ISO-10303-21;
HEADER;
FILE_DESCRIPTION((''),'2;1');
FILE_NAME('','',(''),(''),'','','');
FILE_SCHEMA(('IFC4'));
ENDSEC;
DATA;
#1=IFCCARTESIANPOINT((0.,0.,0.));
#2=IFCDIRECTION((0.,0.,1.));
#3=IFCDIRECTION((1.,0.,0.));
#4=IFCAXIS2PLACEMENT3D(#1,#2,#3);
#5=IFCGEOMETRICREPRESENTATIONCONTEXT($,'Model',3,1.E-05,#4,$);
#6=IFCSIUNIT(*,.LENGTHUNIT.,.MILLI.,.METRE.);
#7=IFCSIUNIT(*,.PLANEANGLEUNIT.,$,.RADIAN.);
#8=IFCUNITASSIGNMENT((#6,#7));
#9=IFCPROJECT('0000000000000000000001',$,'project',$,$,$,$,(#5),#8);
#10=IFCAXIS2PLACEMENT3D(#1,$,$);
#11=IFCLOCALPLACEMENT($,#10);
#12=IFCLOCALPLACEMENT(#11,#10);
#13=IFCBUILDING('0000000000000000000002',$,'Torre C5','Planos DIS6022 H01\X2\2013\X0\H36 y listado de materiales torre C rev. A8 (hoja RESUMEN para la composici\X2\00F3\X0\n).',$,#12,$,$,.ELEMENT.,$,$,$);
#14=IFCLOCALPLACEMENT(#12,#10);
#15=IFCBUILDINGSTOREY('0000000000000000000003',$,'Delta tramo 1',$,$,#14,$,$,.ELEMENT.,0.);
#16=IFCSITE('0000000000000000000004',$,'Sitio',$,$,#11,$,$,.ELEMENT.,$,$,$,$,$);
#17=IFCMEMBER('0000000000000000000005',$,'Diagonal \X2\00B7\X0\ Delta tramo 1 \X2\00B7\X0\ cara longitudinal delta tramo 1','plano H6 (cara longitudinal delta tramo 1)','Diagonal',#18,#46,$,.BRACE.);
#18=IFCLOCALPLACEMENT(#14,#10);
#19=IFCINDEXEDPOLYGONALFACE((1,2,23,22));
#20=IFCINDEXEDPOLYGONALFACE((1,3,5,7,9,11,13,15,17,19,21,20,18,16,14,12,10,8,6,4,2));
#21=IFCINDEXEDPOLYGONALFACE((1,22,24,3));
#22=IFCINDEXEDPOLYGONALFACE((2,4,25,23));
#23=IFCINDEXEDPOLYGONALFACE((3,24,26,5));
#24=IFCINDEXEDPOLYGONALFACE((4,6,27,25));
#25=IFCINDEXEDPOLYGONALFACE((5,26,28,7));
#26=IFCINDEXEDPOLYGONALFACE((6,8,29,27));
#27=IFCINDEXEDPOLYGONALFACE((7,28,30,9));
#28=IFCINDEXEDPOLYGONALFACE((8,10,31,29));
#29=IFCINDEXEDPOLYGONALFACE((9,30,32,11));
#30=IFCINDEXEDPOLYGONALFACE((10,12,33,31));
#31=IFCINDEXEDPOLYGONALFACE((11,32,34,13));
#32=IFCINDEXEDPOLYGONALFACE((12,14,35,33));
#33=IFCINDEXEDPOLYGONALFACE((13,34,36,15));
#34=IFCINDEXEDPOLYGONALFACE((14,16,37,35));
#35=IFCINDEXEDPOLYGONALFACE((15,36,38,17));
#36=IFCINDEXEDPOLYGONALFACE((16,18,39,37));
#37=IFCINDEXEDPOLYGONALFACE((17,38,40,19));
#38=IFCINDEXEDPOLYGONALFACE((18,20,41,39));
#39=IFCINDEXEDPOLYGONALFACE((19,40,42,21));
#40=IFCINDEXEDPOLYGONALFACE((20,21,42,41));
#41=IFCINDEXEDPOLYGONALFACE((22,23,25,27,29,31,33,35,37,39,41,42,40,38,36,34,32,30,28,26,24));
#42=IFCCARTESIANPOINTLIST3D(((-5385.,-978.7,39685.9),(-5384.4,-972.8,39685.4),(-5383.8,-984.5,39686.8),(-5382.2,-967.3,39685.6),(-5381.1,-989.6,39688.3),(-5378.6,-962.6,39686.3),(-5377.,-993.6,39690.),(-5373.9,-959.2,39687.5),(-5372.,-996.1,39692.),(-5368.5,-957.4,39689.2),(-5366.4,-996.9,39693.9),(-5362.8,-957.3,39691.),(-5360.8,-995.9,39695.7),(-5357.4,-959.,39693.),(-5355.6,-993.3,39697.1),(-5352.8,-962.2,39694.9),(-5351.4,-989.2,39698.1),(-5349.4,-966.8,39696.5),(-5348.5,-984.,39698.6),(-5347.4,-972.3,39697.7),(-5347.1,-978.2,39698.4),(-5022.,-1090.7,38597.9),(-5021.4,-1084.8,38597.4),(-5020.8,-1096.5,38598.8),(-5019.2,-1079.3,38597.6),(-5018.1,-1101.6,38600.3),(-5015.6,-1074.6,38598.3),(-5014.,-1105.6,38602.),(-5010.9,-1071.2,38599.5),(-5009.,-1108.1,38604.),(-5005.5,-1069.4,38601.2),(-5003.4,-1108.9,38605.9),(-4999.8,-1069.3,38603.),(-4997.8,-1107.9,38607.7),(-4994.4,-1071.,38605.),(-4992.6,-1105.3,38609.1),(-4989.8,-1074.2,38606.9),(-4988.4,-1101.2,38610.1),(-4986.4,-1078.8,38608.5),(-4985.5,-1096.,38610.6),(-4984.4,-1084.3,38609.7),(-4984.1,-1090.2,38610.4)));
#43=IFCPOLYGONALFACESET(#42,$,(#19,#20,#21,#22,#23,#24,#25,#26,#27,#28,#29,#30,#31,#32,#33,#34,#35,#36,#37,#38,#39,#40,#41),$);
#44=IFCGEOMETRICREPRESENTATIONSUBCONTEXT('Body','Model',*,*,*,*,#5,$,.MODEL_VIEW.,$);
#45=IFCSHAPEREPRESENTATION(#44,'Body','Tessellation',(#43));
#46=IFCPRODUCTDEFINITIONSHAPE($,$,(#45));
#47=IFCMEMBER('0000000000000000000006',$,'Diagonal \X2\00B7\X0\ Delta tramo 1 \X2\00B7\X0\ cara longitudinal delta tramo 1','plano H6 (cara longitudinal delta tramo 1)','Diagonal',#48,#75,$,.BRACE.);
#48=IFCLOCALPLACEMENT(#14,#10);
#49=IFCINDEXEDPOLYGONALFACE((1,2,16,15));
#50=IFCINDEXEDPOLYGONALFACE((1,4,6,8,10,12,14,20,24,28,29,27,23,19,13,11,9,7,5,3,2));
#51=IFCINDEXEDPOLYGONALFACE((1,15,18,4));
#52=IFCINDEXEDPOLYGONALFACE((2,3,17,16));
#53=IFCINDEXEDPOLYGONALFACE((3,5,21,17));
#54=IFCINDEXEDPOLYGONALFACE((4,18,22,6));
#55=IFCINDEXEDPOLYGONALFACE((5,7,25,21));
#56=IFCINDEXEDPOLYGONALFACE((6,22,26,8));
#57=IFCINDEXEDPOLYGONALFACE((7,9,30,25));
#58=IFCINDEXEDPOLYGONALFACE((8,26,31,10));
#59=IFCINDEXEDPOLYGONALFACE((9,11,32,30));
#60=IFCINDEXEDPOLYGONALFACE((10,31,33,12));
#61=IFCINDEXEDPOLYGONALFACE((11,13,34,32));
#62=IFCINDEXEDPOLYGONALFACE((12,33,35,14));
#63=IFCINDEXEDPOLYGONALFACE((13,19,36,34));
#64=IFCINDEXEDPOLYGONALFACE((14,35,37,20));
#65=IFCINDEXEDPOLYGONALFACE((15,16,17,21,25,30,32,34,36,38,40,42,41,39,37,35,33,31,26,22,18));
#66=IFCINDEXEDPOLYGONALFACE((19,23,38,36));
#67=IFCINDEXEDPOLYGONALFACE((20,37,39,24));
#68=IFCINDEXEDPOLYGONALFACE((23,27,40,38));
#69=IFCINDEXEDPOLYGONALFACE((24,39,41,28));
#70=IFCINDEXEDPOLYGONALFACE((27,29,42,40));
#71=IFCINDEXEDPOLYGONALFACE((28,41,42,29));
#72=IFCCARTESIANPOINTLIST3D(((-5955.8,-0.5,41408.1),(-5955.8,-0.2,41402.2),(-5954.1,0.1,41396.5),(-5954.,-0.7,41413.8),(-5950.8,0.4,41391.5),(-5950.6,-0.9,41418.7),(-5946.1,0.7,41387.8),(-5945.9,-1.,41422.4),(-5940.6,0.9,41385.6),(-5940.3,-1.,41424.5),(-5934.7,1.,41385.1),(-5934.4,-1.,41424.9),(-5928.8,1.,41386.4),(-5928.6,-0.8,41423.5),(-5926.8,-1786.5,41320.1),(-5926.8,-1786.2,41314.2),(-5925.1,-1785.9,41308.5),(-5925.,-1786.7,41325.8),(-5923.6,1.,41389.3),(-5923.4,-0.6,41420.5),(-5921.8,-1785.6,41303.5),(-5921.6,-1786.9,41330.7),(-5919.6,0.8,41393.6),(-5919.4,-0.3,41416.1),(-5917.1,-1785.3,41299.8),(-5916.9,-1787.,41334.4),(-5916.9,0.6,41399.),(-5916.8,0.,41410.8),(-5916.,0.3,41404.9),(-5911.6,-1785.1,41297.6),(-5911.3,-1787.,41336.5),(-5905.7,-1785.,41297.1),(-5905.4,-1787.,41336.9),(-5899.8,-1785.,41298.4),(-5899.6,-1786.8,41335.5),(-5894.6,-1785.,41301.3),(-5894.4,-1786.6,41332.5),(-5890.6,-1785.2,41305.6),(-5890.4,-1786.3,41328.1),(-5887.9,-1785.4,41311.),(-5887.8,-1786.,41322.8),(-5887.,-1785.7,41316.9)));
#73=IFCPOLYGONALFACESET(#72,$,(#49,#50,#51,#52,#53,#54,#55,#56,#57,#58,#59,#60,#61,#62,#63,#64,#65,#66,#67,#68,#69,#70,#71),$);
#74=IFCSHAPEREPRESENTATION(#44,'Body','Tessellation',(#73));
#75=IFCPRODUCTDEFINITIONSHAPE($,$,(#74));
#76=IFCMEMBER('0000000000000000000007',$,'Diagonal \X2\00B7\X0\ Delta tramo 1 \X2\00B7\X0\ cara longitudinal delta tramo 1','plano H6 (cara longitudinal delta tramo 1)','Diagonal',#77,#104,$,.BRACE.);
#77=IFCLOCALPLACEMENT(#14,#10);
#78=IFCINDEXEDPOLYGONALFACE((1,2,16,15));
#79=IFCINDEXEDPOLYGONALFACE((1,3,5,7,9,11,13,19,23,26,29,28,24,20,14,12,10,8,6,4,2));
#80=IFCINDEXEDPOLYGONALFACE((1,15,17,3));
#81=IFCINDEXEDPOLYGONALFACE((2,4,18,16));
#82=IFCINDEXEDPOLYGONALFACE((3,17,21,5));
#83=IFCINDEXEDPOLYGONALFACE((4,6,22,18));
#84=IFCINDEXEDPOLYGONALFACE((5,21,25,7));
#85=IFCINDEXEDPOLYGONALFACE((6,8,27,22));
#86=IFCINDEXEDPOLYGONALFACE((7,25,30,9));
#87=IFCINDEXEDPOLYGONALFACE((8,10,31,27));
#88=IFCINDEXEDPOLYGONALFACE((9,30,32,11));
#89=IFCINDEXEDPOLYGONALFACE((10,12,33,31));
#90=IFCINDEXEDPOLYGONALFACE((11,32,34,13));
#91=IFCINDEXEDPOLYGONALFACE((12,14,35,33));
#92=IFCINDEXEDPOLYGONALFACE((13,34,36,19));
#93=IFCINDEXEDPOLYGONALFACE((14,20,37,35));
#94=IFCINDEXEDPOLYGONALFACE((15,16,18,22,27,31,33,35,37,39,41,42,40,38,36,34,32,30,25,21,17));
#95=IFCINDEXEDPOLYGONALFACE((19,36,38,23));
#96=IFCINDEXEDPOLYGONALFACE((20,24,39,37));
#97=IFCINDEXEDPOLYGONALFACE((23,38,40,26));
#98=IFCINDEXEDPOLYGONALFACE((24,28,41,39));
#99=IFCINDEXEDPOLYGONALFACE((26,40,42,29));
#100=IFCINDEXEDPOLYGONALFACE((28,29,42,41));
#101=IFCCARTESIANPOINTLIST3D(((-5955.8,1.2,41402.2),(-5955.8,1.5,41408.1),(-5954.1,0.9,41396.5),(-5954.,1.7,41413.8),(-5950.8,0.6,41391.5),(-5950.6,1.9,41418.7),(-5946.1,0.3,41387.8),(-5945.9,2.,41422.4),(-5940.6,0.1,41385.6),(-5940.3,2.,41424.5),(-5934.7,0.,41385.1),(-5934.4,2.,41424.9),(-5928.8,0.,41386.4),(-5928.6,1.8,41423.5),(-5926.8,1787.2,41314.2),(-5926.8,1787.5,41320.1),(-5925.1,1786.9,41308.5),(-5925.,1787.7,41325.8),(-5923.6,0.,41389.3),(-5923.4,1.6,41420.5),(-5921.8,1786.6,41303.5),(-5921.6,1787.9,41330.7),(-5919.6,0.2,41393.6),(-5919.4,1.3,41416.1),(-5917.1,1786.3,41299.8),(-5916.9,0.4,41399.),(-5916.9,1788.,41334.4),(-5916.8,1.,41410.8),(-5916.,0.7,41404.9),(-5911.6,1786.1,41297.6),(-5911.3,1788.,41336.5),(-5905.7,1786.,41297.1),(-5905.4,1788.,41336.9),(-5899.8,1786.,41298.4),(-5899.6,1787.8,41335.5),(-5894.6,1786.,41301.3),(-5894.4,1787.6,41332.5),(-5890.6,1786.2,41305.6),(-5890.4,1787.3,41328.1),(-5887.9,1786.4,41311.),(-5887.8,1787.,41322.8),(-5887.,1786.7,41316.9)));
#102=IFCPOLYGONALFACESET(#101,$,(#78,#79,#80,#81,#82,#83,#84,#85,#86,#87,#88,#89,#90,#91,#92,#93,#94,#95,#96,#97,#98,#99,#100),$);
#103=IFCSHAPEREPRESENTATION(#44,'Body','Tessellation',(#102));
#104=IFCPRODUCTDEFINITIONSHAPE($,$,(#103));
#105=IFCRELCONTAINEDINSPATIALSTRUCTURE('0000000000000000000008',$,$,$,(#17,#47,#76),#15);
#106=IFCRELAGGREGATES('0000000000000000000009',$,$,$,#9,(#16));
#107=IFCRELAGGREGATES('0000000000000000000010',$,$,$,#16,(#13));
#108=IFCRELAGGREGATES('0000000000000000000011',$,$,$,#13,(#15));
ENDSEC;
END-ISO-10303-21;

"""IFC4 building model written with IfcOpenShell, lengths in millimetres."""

from ifc_helpers import new_model, si_unit, frame, origin, origin_with_axes, place, context, subcontext, project, spatial, circle, extrude, element, save


model = new_model("IFC4")

# Units and contexts
model_context = context("Model", 3, precision=1e-05, world=origin_with_axes())
body_context = subcontext(model_context, "Body", "Model", "MODEL_VIEW")
ifc_project = project(units=[si_unit("LENGTHUNIT", "METRE", prefix="MILLI"), si_unit("PLANEANGLEUNIT", "RADIAN")], contexts=[model_context])

# Site, building, storey
site_placement = place(None, origin())
site = spatial("IfcSite", under=ifc_project, at=site_placement, Name="Sitio", CompositionType="ELEMENT")
building_placement = place(site_placement, origin())
building = spatial("IfcBuilding", under=site, at=building_placement, Name="Torre C5", Description="Planos DIS6022 H01–H36 y listado de materiales torre C rev. A8 (hoja RESUMEN para la composición).", CompositionType="ELEMENT")
storey_placement = place(building_placement, origin())
storey = spatial("IfcBuildingStorey", under=building, at=storey_placement, Name="Delta tramo 1", CompositionType="ELEMENT", Elevation=0.0)

# Members
member_1_placement = place(storey_placement, frame((-5366.0, -977.0, 39692.0), z_axis=(0.314991, -0.097187, -0.944106), x_axis=(0.929313, 0.233618, 0.286007)))
element("IfcMember", 1, at=member_1_placement, inside=storey, Name="Diagonal · Delta tramo 1 · cara longitudinal delta tramo 1", Description="plano H6 (cara longitudinal delta tramo 1)", ObjectType="Diagonal", PredefinedType="BRACE", context=body_context, shape_type="SweptSolid", body=[
    extrude(circle(Radius=20.0), None, (0.0, 0.0, 1.0), 1152.4),
])
for number, where, z_axis, x_axis, name in (
    (2, (-5936.0, 0.0, 41405.0), (0.016216, -0.998657, -0.049206), (0.999841, 0.01656, -0.006597), "Diagonal · Delta tramo 1 · cara longitudinal delta tramo 1"),
    (3, (-5936.0, 1.0, 41405.0), (0.016216, 0.998657, -0.049206), (0.999841, -0.01656, -0.006606), "Diagonal · Delta tramo 1 · cara longitudinal delta tramo 1"),
):
    element("IfcMember", number, at=place(storey_placement, frame(where, z_axis=z_axis, x_axis=x_axis)), inside=storey, Name=name, Description="plano H6 (cara longitudinal delta tramo 1)", ObjectType="Diagonal", PredefinedType="BRACE", context=body_context, shape_type="SweptSolid", body=[
        extrude(circle(Radius=20.0), None, (0.0, 0.0, 1.0), 1788.4),
    ])

save(model, "model.ifc")
